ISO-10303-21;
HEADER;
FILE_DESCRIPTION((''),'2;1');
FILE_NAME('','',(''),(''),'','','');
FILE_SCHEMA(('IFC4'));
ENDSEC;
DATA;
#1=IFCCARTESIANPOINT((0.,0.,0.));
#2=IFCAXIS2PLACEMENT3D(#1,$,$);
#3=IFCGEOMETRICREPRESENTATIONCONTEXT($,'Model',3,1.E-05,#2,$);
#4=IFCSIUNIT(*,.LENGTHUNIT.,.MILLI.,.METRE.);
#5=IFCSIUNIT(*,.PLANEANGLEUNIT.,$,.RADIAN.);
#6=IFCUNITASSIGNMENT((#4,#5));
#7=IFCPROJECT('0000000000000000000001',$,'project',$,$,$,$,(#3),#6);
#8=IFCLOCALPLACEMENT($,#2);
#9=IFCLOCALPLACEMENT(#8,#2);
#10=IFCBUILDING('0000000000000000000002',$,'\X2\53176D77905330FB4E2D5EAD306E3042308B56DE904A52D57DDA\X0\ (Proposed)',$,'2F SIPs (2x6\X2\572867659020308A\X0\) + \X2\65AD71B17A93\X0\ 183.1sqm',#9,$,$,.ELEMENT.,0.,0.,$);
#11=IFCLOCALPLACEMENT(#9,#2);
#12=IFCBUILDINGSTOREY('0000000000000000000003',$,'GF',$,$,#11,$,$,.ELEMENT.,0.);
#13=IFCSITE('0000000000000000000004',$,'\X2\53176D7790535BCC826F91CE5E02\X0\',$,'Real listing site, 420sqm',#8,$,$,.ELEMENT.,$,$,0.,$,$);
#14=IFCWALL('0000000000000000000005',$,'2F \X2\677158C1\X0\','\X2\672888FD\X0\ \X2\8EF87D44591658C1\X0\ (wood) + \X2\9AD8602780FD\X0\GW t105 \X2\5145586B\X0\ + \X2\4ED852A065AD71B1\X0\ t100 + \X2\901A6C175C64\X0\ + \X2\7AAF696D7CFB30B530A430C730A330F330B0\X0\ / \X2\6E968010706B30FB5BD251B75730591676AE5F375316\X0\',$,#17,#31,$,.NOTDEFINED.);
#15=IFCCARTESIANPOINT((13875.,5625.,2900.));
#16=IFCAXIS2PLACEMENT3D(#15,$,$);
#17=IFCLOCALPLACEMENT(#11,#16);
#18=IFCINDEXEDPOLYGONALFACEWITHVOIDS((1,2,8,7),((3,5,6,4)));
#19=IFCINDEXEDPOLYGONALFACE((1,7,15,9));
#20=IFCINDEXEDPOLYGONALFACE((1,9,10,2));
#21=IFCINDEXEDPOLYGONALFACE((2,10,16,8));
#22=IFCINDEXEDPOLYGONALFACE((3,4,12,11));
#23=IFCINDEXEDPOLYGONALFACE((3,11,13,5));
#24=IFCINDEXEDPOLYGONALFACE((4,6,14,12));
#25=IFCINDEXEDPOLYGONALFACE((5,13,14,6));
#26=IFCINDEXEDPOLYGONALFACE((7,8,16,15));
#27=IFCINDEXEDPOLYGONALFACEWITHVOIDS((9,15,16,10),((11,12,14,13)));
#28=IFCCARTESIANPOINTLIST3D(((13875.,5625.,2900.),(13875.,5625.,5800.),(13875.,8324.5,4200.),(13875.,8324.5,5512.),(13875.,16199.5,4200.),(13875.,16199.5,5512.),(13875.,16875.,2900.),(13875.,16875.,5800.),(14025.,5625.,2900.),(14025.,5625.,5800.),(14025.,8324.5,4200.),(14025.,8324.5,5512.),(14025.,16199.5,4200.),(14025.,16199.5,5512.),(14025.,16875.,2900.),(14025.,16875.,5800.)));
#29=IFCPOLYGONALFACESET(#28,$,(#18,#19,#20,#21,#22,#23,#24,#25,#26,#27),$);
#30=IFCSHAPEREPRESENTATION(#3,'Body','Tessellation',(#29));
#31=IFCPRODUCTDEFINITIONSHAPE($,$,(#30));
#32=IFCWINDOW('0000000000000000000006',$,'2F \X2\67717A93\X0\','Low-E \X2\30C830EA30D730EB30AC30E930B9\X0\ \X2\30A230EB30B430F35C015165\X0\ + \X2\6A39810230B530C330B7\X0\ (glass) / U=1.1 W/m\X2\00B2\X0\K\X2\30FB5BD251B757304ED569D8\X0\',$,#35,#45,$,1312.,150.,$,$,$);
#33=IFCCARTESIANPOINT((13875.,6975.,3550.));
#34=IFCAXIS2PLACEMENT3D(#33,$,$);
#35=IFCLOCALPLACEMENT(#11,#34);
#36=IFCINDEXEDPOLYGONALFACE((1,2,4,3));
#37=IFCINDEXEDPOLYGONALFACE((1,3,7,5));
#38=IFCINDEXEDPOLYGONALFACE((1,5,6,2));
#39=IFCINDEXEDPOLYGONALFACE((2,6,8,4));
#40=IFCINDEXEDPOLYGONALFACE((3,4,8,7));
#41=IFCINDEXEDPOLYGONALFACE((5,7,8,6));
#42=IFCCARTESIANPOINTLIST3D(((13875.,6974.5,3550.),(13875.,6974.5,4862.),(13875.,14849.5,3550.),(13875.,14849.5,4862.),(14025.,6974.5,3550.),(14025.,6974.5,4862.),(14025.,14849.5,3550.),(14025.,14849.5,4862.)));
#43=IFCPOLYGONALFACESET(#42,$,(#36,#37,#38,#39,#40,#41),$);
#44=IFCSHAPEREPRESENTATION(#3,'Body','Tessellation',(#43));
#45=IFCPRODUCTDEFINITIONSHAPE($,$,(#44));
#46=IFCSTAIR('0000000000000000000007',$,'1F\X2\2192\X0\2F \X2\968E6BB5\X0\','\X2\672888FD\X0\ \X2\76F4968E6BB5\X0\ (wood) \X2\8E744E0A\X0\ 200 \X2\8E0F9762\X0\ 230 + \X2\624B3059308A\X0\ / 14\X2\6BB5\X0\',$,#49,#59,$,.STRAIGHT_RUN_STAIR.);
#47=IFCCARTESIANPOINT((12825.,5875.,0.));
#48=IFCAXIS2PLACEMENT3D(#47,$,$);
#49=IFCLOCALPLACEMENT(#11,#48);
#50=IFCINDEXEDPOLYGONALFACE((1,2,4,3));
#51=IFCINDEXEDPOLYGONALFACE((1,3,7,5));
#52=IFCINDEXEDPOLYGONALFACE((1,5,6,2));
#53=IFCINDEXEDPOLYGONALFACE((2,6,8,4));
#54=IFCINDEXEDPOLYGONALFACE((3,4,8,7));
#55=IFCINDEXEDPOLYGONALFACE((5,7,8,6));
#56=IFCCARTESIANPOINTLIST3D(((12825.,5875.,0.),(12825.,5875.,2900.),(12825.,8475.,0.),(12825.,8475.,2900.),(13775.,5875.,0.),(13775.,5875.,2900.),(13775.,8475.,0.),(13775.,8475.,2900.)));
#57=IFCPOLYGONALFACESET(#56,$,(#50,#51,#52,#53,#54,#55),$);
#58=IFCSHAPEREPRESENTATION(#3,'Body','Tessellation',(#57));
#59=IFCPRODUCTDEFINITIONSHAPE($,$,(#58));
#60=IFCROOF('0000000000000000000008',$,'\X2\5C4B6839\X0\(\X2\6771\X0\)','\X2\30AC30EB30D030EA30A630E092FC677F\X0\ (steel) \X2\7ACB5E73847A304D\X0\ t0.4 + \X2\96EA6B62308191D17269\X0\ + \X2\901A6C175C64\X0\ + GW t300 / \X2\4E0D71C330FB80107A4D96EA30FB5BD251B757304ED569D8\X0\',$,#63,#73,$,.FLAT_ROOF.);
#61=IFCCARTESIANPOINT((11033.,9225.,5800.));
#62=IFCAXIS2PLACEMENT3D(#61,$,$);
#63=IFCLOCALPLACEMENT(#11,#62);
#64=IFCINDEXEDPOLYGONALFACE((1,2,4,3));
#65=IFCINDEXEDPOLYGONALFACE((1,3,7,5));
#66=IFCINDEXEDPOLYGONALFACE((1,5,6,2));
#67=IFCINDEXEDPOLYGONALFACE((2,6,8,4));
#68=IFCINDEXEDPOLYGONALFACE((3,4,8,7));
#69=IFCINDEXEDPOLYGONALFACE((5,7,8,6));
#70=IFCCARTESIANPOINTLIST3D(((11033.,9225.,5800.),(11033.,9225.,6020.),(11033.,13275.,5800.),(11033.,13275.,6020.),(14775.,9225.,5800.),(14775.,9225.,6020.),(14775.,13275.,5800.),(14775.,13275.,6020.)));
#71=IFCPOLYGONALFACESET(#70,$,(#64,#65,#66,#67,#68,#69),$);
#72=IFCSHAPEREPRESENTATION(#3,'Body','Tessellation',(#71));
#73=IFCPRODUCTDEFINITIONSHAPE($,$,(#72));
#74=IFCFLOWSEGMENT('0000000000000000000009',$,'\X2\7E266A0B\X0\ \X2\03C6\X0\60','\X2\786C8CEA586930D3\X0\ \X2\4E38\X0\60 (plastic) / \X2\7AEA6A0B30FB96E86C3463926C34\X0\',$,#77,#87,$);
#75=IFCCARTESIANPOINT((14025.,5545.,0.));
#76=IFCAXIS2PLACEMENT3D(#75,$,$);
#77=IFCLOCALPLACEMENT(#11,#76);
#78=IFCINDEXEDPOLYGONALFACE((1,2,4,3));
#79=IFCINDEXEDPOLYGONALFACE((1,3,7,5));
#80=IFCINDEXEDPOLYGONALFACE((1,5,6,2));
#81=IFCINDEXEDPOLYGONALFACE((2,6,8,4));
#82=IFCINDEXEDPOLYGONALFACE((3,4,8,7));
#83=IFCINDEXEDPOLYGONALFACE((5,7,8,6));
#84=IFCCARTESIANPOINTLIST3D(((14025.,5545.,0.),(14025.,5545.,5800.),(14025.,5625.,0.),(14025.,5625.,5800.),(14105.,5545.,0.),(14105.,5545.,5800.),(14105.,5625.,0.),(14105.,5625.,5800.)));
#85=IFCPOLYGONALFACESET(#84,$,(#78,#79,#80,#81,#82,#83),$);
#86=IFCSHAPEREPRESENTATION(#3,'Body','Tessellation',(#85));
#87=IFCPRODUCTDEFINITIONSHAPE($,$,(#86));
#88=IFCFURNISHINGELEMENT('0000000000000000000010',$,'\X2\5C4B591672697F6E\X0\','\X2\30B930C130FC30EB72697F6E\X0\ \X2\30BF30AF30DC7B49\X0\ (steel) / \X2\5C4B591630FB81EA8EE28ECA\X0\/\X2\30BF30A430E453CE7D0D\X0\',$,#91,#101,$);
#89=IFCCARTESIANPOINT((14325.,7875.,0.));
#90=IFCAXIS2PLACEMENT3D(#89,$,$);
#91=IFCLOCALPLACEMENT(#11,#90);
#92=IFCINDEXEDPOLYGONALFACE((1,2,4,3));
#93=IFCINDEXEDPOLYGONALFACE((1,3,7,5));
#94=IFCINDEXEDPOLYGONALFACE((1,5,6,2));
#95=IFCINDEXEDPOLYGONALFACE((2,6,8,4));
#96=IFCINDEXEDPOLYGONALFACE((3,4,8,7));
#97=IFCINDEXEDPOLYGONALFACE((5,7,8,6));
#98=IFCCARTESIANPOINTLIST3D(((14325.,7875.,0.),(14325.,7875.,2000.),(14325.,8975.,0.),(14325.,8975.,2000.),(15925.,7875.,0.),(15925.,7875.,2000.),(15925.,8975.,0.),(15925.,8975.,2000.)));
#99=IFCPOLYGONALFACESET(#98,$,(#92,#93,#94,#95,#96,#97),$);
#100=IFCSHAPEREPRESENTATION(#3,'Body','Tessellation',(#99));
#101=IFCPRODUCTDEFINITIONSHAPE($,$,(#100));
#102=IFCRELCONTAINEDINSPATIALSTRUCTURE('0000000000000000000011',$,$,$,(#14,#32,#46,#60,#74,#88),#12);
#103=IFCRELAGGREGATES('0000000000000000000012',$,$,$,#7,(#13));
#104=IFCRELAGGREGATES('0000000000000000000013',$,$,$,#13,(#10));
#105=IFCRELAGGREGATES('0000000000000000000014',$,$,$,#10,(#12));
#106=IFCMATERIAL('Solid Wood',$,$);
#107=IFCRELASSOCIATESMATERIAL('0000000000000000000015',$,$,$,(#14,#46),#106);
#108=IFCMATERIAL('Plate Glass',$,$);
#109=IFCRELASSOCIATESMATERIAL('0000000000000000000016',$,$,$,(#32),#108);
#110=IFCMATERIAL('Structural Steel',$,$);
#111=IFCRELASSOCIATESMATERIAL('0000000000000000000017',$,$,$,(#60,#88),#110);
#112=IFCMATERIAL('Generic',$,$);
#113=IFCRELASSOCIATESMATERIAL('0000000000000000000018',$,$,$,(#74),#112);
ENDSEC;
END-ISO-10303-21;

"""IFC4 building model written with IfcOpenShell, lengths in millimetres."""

from ifc_helpers import new_model, si_unit, frame, frame_2d, origin, place, context, project, spatial, rectangle, extrude, material, element, fill, save


model = new_model("IFC4")

# Units and contexts
model_context = context("Model", 3, precision=1e-05, world=origin())
ifc_project = project(units=[si_unit("LENGTHUNIT", "METRE", prefix="MILLI"), si_unit("PLANEANGLEUNIT", "RADIAN")], contexts=[model_context])

# Site, building, storey
site_placement = place(None, origin())
site = spatial("IfcSite", under=ifc_project, at=site_placement, Name="北海道富良野市", ObjectType="Real listing site, 420sqm", CompositionType="ELEMENT", RefElevation=0.0)
building_placement = place(site_placement, origin())
building = spatial("IfcBuilding", under=site, at=building_placement, Name="北海道・中庭のある回遊動線 (Proposed)", ObjectType="2F SIPs (2x6在来造り) + 断熱窓 183.1sqm", CompositionType="ELEMENT", ElevationOfRefHeight=0.0, ElevationOfTerrain=0.0)
storey_placement = place(building_placement, origin())
storey = spatial("IfcBuildingStorey", under=building, at=storey_placement, Name="GF", CompositionType="ELEMENT", Elevation=0.0)

# Shared definitions
ifc_material_1 = material(Name="Solid Wood")

# Wall, opening, window
ifc_material_2 = material(Name="Plate Glass")
wall_1_placement = place(storey_placement, frame((13875.0, 5625.0, 2900.0)))
wall_1 = element("IfcWall", 1, at=wall_1_placement, inside=storey, material=ifc_material_1, Name="2F 東壁", Description="木製 軸組外壁 (wood) + 高性能GW t105 充填 + 付加断熱 t100 + 通気層 + 窯業系サイディング / 準耐火・寒冷地外皮強化", PredefinedType="NOTDEFINED", context=model_context, shape_type="SweptSolid", body=[
    extrude(rectangle(XDim=150.0, YDim=11250.0, at=frame_2d((75.0, 5625.0))), frame((13875.0, 5625.0, 2900.0)), (0.0, 0.0, 1.0), 2900.0),
])
opening_1_placement = place(storey_placement, frame((13875.0, 6975.0, 3550.0)))
opening_1 = element("IfcOpeningElement", 2, at=opening_1_placement, cuts=wall_1, PredefinedType="NOTDEFINED", context=model_context, shape_type="SweptSolid", body=[
    extrude(rectangle(XDim=150.0, YDim=7875.0, at=frame_2d((75.0, 3937.0))), frame((13875.0, 6975.0, 3550.0)), (0.0, 0.0, 1.0), 1312.0),
])
window_1_placement = place(storey_placement, frame((13875.0, 6975.0, 3550.0)))
window_1 = element("IfcWindow", 3, at=window_1_placement, inside=storey, material=ifc_material_2, Name="2F 東窓", Description="Low-E トリプルガラス アルゴン封入 + 樹脂サッシ (glass) / U=1.1 W/m²K・寒冷地仕様", OverallHeight=1312.0, OverallWidth=150.0, context=model_context, shape_type="SweptSolid", body=[
    extrude(rectangle(XDim=150.0, YDim=7875.0, at=frame_2d((75.0, 3937.0))), frame((13875.0, 6975.0, 3550.0)), (0.0, 0.0, 1.0), 1312.0),
])
fill(opening_1, window_1)

# Stair
stair_placement = place(storey_placement, frame((12825.0, 5875.0, 0.0)))
element("IfcStair", 4, at=stair_placement, inside=storey, material=ifc_material_1, Name="1F→2F 階段", Description="木製 直階段 (wood) 蹴上 200 踏面 230 + 手すり / 14段", PredefinedType="STRAIGHT_RUN_STAIR", context=model_context, shape_type="SweptSolid", body=[
    extrude(rectangle(XDim=950.0, YDim=2600.0, at=frame_2d((475.0, 1300.0))), frame((12825.0, 5875.0, 0.0)), (0.0, 0.0, 1.0), 2900.0),
])

# Roof
ifc_material_3 = material(Name="Structural Steel")
roof_placement = place(storey_placement, frame((11033.0, 9225.0, 5800.0)))
element("IfcRoof", 5, at=roof_placement, inside=storey, material=ifc_material_3, Name="屋根(東)", Description="ガルバリウム鋼板 (steel) 立平葺き t0.4 + 雪止め金物 + 通気層 + GW t300 / 不燃・耐積雪・寒冷地仕様", PredefinedType="FLAT_ROOF", context=model_context, shape_type="SweptSolid", body=[
    extrude(rectangle(XDim=3742.0, YDim=4050.0, at=frame_2d((1871.0, 2025.0))), frame((11033.0, 9225.0, 5800.0)), (0.0, 0.0, 1.0), 220.0),
])

# Flow segment
ifc_material_4 = material(Name="Generic")
flow_segment_placement = place(storey_placement, frame((14025.0, 5545.0, 0.0)))
element("IfcFlowSegment", 6, at=flow_segment_placement, inside=storey, material=ifc_material_4, Name="縦樋 φ60", Description="硬質塩ビ 丸60 (plastic) / 竪樋・雨水排水", context=model_context, shape_type="SweptSolid", body=[
    extrude(rectangle(XDim=80.0, YDim=80.0, at=frame_2d((40.0, 40.0))), frame((14025.0, 5545.0, 0.0)), (0.0, 0.0, 1.0), 5800.0),
])

# Furnishing element
furnishing_placement = place(storey_placement, frame((14325.0, 7875.0, 0.0)))
element("IfcFurnishingElement", 7, at=furnishing_placement, inside=storey, material=ifc_material_3, Name="屋外物置", Description="スチール物置 タクボ等 (steel) / 屋外・自転車/タイヤ収納", context=model_context, shape_type="SweptSolid", body=[
    extrude(rectangle(XDim=1600.0, YDim=1100.0, at=frame_2d((800.0, 550.0))), frame((14325.0, 7875.0, 0.0)), (0.0, 0.0, 1.0), 2000.0),
])

save(model, "model.ifc")
